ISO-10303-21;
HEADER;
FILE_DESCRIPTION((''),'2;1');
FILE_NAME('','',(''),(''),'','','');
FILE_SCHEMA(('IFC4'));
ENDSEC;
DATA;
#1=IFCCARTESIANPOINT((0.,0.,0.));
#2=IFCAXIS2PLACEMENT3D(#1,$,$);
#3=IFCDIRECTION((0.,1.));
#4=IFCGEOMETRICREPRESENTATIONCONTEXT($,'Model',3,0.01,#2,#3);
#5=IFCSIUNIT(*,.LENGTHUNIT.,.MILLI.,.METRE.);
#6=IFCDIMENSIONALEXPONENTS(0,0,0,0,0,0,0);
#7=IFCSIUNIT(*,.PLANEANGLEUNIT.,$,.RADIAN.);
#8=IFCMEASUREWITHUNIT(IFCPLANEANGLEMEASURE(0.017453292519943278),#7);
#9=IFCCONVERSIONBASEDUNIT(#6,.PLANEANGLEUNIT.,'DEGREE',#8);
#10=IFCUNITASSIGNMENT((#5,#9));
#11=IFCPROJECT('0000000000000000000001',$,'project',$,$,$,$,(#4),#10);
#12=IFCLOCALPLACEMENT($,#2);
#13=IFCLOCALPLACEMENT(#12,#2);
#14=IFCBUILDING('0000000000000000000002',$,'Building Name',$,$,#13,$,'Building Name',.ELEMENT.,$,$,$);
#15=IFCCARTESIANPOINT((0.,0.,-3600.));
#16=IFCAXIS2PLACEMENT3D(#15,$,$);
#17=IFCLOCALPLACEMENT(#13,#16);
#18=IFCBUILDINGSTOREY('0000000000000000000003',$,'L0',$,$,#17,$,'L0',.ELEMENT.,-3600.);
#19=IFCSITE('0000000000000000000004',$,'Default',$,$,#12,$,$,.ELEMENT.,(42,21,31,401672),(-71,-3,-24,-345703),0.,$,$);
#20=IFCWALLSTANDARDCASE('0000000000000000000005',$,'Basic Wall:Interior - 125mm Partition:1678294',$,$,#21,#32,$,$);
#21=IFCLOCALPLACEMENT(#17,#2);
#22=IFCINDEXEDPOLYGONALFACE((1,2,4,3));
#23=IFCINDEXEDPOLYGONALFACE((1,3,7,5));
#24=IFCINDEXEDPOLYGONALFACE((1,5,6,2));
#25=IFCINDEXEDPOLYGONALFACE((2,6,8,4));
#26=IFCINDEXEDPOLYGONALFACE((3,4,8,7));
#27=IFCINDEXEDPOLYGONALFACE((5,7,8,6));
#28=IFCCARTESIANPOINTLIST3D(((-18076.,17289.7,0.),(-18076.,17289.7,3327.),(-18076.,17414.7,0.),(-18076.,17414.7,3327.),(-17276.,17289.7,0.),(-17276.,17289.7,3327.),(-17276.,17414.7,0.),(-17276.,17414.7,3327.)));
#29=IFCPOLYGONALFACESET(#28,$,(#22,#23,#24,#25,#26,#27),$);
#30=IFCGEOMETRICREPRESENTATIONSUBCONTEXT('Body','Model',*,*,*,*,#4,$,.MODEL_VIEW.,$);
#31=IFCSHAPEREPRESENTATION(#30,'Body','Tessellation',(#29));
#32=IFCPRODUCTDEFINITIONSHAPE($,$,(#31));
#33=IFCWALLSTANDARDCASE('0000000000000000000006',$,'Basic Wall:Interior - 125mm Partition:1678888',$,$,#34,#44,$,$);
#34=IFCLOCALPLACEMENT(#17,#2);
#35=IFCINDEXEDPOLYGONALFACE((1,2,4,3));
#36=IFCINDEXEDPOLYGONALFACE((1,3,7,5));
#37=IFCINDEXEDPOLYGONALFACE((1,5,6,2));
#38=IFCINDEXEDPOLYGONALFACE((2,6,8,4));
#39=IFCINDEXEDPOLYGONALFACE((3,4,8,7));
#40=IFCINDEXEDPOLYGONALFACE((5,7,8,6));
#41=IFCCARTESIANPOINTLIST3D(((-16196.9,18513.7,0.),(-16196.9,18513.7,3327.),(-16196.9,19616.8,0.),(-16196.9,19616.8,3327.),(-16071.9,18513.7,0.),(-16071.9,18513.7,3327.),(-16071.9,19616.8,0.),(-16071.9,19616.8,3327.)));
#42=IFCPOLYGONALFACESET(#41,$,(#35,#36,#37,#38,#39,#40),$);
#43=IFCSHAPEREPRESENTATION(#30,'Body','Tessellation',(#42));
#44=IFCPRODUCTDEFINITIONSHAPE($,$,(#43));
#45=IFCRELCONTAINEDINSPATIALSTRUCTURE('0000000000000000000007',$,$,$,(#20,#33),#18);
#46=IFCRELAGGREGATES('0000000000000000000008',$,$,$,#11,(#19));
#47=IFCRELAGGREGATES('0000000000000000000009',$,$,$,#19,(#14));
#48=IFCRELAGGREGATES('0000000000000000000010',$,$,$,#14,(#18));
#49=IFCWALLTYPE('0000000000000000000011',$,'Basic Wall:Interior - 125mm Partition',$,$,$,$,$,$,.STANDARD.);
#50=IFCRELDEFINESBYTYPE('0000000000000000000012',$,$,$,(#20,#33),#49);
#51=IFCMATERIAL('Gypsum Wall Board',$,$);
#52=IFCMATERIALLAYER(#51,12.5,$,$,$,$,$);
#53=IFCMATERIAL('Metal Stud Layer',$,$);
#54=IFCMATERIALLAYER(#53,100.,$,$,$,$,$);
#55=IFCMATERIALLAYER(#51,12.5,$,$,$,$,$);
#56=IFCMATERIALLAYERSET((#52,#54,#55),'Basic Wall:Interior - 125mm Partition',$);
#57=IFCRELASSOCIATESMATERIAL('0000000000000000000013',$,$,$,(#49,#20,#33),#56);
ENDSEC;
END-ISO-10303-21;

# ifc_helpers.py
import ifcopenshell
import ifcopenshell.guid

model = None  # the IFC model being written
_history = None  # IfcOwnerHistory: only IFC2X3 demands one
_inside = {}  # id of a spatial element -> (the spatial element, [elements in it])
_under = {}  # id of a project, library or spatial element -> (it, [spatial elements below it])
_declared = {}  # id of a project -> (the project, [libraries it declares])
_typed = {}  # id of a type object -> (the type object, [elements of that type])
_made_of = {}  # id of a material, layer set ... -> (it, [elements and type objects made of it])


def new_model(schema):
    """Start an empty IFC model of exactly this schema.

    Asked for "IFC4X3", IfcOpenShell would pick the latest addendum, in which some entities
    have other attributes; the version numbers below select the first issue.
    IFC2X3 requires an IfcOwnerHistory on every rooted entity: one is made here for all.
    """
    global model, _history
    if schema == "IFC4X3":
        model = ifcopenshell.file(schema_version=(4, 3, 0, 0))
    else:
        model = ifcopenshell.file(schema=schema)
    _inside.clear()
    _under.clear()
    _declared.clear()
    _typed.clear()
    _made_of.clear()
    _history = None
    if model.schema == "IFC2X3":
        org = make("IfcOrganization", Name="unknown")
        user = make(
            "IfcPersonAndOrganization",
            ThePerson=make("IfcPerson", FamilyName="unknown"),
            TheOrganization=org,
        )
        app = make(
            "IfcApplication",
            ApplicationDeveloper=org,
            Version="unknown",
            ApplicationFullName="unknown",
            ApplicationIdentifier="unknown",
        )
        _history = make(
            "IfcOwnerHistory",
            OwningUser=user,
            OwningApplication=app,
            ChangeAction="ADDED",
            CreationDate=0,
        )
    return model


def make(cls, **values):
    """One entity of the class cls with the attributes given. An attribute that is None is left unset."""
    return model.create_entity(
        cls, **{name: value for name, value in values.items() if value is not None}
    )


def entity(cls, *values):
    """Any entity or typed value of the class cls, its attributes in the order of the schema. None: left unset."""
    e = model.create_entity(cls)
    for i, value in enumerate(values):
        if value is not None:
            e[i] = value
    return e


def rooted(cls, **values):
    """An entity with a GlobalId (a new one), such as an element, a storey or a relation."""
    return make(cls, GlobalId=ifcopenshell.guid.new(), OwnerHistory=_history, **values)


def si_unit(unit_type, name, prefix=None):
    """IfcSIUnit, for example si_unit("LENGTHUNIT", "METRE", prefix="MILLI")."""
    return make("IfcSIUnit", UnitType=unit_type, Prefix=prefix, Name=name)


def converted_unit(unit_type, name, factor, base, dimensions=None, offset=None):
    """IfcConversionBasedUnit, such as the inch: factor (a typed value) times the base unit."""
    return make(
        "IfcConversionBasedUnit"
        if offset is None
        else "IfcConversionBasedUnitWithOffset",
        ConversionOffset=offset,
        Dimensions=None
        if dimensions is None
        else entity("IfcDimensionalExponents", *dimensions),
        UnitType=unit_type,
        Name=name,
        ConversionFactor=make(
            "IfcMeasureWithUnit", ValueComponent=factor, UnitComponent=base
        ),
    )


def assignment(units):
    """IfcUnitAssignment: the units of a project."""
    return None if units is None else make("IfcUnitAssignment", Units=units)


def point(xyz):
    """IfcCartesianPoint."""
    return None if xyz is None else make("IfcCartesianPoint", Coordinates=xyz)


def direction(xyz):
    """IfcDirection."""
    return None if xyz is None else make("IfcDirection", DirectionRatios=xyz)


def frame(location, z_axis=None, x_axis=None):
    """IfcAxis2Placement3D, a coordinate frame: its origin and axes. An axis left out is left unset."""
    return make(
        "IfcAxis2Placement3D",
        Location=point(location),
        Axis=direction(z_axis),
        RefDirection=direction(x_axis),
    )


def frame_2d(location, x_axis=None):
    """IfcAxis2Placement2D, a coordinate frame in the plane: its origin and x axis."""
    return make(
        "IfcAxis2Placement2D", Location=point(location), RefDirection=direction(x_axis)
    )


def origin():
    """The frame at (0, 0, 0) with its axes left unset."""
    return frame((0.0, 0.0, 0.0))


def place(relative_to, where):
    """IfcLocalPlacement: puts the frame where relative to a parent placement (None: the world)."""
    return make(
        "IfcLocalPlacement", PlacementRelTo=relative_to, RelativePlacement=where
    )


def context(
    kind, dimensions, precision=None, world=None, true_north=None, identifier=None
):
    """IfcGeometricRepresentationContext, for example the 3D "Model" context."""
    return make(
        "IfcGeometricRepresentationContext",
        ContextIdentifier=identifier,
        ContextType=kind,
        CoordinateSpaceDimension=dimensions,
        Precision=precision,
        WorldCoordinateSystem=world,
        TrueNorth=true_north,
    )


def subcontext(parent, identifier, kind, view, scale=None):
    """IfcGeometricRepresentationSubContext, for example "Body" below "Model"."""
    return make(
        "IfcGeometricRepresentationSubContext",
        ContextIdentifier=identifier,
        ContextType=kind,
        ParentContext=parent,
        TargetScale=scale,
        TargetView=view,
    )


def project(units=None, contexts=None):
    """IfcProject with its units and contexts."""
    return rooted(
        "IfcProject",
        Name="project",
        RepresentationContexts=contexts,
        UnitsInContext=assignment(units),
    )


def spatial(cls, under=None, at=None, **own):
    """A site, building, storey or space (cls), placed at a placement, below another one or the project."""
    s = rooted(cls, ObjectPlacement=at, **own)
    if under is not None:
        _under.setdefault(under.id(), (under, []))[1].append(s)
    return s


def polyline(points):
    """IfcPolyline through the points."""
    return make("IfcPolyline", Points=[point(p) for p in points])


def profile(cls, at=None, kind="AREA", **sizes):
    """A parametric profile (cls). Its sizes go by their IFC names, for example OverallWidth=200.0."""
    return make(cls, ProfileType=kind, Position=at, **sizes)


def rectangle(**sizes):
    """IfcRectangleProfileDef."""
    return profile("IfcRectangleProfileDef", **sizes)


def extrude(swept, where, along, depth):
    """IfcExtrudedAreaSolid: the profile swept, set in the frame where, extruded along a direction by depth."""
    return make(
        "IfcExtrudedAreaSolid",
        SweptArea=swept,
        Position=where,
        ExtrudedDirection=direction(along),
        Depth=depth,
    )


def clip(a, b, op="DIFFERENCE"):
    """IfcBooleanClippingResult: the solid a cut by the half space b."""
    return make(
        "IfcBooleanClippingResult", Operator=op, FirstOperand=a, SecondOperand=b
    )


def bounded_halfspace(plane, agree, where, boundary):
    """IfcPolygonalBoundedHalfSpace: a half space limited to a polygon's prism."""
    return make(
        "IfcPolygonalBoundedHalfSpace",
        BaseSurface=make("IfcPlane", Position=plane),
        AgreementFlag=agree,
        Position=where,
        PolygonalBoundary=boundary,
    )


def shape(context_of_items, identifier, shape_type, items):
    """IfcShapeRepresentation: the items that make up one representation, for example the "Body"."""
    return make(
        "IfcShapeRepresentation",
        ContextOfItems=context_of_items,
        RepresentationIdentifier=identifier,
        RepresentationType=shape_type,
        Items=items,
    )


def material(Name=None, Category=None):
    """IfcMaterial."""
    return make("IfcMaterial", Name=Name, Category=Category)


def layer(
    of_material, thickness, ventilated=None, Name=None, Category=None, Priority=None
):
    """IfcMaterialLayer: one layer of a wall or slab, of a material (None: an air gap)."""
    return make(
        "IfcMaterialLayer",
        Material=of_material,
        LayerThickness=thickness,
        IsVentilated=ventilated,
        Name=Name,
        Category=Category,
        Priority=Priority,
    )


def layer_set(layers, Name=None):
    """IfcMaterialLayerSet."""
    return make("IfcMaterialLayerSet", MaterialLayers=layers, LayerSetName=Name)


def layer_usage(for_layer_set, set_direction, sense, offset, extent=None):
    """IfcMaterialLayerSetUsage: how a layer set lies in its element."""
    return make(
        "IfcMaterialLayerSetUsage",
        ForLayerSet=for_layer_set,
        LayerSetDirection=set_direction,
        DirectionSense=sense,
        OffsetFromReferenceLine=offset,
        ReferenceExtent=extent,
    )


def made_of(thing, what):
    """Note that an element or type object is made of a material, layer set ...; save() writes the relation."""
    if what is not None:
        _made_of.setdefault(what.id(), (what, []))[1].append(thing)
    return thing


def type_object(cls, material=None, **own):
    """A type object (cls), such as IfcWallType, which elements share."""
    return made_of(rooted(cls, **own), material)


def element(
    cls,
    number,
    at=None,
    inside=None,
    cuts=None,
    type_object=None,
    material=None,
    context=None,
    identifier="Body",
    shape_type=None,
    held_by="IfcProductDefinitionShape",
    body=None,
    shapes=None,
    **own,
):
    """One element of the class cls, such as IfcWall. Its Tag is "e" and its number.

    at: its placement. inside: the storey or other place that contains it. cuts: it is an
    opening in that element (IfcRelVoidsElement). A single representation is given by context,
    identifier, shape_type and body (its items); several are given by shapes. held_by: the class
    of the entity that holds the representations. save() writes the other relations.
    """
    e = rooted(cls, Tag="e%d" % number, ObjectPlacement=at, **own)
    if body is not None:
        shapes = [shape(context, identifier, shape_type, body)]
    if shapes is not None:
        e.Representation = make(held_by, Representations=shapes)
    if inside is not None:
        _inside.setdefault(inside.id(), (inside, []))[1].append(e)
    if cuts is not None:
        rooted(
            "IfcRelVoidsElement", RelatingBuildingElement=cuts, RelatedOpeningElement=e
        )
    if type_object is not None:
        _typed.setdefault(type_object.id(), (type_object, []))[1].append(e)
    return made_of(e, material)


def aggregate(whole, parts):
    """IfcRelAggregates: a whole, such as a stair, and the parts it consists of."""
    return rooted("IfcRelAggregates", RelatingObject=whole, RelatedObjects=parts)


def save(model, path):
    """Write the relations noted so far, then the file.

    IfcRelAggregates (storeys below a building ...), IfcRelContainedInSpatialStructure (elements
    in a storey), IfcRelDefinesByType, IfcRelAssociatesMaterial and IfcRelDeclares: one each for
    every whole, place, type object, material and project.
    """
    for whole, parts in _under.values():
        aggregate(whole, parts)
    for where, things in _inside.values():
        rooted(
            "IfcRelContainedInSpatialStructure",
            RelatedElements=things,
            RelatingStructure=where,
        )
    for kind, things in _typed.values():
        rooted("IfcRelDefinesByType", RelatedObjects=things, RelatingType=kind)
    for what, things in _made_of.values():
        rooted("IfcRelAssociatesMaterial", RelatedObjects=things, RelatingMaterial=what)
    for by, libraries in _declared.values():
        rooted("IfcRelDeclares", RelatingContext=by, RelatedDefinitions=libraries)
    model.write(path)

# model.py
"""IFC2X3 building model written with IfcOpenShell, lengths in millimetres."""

from ifc_helpers import new_model, entity, si_unit, converted_unit, direction, frame, frame_2d, origin, place, context, subcontext, project, spatial, polyline, rectangle, extrude, clip, bounded_halfspace, material, layer, layer_set, layer_usage, type_object, element, save


model = new_model("IFC2X3")

# Units and contexts
model_context = context("Model", 3, precision=0.01, world=origin(), true_north=direction((0.0, 1.0)))
body_context = subcontext(model_context, "Body", "Model", "MODEL_VIEW")
ifc_project = project(units=[si_unit("LENGTHUNIT", "METRE", prefix="MILLI"), converted_unit("PLANEANGLEUNIT", "DEGREE", entity("IfcPlaneAngleMeasure", 0.017453292519943278), si_unit("PLANEANGLEUNIT", "RADIAN"), dimensions=[0, 0, 0, 0, 0, 0, 0])], contexts=[model_context])

# Site, building, storey
site_placement = place(None, origin())
site = spatial("IfcSite", under=ifc_project, at=site_placement, Name="Default", CompositionType="ELEMENT", RefLatitude=(42, 21, 31, 401672), RefLongitude=(-71, -3, -24, -345703), RefElevation=0.0)
building_placement = place(site_placement, origin())
building = spatial("IfcBuilding", under=site, at=building_placement, Name="Building Name", LongName="Building Name", CompositionType="ELEMENT")
storey_placement = place(building_placement, frame((0.0, 0.0, -3600.0)))
storey = spatial("IfcBuildingStorey", under=building, at=storey_placement, Name="L0", LongName="L0", CompositionType="ELEMENT", Elevation=-3600.0)

# Shared definitions
ifc_material_1 = material(Name="Gypsum Wall Board")

# Shared definitions
ifc_layer_1 = layer(ifc_material_1, 12.5)
ifc_material_2 = material(Name="Metal Stud Layer")
ifc_layer_2 = layer(ifc_material_2, 100.0)
ifc_layer_3 = layer(ifc_material_1, 12.5)
ifc_layer_set_1 = layer_set([ifc_layer_1, ifc_layer_2, ifc_layer_3], Name="Basic Wall:Interior - 125mm Partition")
wall_type_1 = type_object("IfcWallType", Name="Basic Wall:Interior - 125mm Partition", PredefinedType="STANDARD", material=ifc_layer_set_1)

# Walls
ifc_layer_usage_1 = layer_usage(ifc_layer_set_1, "AXIS2", "NEGATIVE", 62.5)
wall_1_placement = place(storey_placement, frame((-17276.0, 17352.2, 0.0), z_axis=(0.0, 0.0, 1.0), x_axis=(-1.0, 0.0, 0.0)))
element("IfcWallStandardCase", 1, at=wall_1_placement, inside=storey, type_object=wall_type_1, material=ifc_layer_usage_1, Name="Basic Wall:Interior - 125mm Partition:1678294", context=body_context, shape_type="Clipping", body=[
    clip(extrude(rectangle(XDim=800.0, YDim=125.0, at=frame_2d((400.0, 0.0), x_axis=(-1.0, 0.0))), origin(), (0.0, 0.0, 1.0), 3327.0), bounded_halfspace(frame((0.0, -62.5, 3327.0), z_axis=(0.0, 0.0, -1.0), x_axis=(0.0, -1.0, 0.0)), True, frame((0.0, -62.5, 3327.0)), polyline([(0.0, 0.0), (800.0, 0.0), (800.0, 125.0), (0.0, 125.0), (0.0, 0.0)]))),
])
ifc_layer_usage_2 = layer_usage(ifc_layer_set_1, "AXIS2", "NEGATIVE", 62.5)
wall_2_placement = place(storey_placement, frame((-16134.4, 19616.8, 0.0), z_axis=(0.0, 0.0, 1.0), x_axis=(0.0, -1.0, 0.0)))
element("IfcWallStandardCase", 2, at=wall_2_placement, inside=storey, type_object=wall_type_1, material=ifc_layer_usage_2, Name="Basic Wall:Interior - 125mm Partition:1678888", context=body_context, shape_type="Clipping", body=[
    clip(extrude(rectangle(XDim=1103.1, YDim=125.0, at=frame_2d((551.6, 0.0), x_axis=(-1.0, 0.0))), origin(), (0.0, 0.0, 1.0), 3327.0), bounded_halfspace(frame((0.0, -62.5, 3327.0), z_axis=(0.0, 0.0, -1.0), x_axis=(-1.0, 0.0, 0.0)), True, frame((0.0, -62.5, 3327.0)), polyline([(0.0, 0.0), (1103.1, 0.0), (1103.1, 125.0), (0.0, 125.0), (0.0, 0.0)]))),
])

save(model, "model.ifc")
